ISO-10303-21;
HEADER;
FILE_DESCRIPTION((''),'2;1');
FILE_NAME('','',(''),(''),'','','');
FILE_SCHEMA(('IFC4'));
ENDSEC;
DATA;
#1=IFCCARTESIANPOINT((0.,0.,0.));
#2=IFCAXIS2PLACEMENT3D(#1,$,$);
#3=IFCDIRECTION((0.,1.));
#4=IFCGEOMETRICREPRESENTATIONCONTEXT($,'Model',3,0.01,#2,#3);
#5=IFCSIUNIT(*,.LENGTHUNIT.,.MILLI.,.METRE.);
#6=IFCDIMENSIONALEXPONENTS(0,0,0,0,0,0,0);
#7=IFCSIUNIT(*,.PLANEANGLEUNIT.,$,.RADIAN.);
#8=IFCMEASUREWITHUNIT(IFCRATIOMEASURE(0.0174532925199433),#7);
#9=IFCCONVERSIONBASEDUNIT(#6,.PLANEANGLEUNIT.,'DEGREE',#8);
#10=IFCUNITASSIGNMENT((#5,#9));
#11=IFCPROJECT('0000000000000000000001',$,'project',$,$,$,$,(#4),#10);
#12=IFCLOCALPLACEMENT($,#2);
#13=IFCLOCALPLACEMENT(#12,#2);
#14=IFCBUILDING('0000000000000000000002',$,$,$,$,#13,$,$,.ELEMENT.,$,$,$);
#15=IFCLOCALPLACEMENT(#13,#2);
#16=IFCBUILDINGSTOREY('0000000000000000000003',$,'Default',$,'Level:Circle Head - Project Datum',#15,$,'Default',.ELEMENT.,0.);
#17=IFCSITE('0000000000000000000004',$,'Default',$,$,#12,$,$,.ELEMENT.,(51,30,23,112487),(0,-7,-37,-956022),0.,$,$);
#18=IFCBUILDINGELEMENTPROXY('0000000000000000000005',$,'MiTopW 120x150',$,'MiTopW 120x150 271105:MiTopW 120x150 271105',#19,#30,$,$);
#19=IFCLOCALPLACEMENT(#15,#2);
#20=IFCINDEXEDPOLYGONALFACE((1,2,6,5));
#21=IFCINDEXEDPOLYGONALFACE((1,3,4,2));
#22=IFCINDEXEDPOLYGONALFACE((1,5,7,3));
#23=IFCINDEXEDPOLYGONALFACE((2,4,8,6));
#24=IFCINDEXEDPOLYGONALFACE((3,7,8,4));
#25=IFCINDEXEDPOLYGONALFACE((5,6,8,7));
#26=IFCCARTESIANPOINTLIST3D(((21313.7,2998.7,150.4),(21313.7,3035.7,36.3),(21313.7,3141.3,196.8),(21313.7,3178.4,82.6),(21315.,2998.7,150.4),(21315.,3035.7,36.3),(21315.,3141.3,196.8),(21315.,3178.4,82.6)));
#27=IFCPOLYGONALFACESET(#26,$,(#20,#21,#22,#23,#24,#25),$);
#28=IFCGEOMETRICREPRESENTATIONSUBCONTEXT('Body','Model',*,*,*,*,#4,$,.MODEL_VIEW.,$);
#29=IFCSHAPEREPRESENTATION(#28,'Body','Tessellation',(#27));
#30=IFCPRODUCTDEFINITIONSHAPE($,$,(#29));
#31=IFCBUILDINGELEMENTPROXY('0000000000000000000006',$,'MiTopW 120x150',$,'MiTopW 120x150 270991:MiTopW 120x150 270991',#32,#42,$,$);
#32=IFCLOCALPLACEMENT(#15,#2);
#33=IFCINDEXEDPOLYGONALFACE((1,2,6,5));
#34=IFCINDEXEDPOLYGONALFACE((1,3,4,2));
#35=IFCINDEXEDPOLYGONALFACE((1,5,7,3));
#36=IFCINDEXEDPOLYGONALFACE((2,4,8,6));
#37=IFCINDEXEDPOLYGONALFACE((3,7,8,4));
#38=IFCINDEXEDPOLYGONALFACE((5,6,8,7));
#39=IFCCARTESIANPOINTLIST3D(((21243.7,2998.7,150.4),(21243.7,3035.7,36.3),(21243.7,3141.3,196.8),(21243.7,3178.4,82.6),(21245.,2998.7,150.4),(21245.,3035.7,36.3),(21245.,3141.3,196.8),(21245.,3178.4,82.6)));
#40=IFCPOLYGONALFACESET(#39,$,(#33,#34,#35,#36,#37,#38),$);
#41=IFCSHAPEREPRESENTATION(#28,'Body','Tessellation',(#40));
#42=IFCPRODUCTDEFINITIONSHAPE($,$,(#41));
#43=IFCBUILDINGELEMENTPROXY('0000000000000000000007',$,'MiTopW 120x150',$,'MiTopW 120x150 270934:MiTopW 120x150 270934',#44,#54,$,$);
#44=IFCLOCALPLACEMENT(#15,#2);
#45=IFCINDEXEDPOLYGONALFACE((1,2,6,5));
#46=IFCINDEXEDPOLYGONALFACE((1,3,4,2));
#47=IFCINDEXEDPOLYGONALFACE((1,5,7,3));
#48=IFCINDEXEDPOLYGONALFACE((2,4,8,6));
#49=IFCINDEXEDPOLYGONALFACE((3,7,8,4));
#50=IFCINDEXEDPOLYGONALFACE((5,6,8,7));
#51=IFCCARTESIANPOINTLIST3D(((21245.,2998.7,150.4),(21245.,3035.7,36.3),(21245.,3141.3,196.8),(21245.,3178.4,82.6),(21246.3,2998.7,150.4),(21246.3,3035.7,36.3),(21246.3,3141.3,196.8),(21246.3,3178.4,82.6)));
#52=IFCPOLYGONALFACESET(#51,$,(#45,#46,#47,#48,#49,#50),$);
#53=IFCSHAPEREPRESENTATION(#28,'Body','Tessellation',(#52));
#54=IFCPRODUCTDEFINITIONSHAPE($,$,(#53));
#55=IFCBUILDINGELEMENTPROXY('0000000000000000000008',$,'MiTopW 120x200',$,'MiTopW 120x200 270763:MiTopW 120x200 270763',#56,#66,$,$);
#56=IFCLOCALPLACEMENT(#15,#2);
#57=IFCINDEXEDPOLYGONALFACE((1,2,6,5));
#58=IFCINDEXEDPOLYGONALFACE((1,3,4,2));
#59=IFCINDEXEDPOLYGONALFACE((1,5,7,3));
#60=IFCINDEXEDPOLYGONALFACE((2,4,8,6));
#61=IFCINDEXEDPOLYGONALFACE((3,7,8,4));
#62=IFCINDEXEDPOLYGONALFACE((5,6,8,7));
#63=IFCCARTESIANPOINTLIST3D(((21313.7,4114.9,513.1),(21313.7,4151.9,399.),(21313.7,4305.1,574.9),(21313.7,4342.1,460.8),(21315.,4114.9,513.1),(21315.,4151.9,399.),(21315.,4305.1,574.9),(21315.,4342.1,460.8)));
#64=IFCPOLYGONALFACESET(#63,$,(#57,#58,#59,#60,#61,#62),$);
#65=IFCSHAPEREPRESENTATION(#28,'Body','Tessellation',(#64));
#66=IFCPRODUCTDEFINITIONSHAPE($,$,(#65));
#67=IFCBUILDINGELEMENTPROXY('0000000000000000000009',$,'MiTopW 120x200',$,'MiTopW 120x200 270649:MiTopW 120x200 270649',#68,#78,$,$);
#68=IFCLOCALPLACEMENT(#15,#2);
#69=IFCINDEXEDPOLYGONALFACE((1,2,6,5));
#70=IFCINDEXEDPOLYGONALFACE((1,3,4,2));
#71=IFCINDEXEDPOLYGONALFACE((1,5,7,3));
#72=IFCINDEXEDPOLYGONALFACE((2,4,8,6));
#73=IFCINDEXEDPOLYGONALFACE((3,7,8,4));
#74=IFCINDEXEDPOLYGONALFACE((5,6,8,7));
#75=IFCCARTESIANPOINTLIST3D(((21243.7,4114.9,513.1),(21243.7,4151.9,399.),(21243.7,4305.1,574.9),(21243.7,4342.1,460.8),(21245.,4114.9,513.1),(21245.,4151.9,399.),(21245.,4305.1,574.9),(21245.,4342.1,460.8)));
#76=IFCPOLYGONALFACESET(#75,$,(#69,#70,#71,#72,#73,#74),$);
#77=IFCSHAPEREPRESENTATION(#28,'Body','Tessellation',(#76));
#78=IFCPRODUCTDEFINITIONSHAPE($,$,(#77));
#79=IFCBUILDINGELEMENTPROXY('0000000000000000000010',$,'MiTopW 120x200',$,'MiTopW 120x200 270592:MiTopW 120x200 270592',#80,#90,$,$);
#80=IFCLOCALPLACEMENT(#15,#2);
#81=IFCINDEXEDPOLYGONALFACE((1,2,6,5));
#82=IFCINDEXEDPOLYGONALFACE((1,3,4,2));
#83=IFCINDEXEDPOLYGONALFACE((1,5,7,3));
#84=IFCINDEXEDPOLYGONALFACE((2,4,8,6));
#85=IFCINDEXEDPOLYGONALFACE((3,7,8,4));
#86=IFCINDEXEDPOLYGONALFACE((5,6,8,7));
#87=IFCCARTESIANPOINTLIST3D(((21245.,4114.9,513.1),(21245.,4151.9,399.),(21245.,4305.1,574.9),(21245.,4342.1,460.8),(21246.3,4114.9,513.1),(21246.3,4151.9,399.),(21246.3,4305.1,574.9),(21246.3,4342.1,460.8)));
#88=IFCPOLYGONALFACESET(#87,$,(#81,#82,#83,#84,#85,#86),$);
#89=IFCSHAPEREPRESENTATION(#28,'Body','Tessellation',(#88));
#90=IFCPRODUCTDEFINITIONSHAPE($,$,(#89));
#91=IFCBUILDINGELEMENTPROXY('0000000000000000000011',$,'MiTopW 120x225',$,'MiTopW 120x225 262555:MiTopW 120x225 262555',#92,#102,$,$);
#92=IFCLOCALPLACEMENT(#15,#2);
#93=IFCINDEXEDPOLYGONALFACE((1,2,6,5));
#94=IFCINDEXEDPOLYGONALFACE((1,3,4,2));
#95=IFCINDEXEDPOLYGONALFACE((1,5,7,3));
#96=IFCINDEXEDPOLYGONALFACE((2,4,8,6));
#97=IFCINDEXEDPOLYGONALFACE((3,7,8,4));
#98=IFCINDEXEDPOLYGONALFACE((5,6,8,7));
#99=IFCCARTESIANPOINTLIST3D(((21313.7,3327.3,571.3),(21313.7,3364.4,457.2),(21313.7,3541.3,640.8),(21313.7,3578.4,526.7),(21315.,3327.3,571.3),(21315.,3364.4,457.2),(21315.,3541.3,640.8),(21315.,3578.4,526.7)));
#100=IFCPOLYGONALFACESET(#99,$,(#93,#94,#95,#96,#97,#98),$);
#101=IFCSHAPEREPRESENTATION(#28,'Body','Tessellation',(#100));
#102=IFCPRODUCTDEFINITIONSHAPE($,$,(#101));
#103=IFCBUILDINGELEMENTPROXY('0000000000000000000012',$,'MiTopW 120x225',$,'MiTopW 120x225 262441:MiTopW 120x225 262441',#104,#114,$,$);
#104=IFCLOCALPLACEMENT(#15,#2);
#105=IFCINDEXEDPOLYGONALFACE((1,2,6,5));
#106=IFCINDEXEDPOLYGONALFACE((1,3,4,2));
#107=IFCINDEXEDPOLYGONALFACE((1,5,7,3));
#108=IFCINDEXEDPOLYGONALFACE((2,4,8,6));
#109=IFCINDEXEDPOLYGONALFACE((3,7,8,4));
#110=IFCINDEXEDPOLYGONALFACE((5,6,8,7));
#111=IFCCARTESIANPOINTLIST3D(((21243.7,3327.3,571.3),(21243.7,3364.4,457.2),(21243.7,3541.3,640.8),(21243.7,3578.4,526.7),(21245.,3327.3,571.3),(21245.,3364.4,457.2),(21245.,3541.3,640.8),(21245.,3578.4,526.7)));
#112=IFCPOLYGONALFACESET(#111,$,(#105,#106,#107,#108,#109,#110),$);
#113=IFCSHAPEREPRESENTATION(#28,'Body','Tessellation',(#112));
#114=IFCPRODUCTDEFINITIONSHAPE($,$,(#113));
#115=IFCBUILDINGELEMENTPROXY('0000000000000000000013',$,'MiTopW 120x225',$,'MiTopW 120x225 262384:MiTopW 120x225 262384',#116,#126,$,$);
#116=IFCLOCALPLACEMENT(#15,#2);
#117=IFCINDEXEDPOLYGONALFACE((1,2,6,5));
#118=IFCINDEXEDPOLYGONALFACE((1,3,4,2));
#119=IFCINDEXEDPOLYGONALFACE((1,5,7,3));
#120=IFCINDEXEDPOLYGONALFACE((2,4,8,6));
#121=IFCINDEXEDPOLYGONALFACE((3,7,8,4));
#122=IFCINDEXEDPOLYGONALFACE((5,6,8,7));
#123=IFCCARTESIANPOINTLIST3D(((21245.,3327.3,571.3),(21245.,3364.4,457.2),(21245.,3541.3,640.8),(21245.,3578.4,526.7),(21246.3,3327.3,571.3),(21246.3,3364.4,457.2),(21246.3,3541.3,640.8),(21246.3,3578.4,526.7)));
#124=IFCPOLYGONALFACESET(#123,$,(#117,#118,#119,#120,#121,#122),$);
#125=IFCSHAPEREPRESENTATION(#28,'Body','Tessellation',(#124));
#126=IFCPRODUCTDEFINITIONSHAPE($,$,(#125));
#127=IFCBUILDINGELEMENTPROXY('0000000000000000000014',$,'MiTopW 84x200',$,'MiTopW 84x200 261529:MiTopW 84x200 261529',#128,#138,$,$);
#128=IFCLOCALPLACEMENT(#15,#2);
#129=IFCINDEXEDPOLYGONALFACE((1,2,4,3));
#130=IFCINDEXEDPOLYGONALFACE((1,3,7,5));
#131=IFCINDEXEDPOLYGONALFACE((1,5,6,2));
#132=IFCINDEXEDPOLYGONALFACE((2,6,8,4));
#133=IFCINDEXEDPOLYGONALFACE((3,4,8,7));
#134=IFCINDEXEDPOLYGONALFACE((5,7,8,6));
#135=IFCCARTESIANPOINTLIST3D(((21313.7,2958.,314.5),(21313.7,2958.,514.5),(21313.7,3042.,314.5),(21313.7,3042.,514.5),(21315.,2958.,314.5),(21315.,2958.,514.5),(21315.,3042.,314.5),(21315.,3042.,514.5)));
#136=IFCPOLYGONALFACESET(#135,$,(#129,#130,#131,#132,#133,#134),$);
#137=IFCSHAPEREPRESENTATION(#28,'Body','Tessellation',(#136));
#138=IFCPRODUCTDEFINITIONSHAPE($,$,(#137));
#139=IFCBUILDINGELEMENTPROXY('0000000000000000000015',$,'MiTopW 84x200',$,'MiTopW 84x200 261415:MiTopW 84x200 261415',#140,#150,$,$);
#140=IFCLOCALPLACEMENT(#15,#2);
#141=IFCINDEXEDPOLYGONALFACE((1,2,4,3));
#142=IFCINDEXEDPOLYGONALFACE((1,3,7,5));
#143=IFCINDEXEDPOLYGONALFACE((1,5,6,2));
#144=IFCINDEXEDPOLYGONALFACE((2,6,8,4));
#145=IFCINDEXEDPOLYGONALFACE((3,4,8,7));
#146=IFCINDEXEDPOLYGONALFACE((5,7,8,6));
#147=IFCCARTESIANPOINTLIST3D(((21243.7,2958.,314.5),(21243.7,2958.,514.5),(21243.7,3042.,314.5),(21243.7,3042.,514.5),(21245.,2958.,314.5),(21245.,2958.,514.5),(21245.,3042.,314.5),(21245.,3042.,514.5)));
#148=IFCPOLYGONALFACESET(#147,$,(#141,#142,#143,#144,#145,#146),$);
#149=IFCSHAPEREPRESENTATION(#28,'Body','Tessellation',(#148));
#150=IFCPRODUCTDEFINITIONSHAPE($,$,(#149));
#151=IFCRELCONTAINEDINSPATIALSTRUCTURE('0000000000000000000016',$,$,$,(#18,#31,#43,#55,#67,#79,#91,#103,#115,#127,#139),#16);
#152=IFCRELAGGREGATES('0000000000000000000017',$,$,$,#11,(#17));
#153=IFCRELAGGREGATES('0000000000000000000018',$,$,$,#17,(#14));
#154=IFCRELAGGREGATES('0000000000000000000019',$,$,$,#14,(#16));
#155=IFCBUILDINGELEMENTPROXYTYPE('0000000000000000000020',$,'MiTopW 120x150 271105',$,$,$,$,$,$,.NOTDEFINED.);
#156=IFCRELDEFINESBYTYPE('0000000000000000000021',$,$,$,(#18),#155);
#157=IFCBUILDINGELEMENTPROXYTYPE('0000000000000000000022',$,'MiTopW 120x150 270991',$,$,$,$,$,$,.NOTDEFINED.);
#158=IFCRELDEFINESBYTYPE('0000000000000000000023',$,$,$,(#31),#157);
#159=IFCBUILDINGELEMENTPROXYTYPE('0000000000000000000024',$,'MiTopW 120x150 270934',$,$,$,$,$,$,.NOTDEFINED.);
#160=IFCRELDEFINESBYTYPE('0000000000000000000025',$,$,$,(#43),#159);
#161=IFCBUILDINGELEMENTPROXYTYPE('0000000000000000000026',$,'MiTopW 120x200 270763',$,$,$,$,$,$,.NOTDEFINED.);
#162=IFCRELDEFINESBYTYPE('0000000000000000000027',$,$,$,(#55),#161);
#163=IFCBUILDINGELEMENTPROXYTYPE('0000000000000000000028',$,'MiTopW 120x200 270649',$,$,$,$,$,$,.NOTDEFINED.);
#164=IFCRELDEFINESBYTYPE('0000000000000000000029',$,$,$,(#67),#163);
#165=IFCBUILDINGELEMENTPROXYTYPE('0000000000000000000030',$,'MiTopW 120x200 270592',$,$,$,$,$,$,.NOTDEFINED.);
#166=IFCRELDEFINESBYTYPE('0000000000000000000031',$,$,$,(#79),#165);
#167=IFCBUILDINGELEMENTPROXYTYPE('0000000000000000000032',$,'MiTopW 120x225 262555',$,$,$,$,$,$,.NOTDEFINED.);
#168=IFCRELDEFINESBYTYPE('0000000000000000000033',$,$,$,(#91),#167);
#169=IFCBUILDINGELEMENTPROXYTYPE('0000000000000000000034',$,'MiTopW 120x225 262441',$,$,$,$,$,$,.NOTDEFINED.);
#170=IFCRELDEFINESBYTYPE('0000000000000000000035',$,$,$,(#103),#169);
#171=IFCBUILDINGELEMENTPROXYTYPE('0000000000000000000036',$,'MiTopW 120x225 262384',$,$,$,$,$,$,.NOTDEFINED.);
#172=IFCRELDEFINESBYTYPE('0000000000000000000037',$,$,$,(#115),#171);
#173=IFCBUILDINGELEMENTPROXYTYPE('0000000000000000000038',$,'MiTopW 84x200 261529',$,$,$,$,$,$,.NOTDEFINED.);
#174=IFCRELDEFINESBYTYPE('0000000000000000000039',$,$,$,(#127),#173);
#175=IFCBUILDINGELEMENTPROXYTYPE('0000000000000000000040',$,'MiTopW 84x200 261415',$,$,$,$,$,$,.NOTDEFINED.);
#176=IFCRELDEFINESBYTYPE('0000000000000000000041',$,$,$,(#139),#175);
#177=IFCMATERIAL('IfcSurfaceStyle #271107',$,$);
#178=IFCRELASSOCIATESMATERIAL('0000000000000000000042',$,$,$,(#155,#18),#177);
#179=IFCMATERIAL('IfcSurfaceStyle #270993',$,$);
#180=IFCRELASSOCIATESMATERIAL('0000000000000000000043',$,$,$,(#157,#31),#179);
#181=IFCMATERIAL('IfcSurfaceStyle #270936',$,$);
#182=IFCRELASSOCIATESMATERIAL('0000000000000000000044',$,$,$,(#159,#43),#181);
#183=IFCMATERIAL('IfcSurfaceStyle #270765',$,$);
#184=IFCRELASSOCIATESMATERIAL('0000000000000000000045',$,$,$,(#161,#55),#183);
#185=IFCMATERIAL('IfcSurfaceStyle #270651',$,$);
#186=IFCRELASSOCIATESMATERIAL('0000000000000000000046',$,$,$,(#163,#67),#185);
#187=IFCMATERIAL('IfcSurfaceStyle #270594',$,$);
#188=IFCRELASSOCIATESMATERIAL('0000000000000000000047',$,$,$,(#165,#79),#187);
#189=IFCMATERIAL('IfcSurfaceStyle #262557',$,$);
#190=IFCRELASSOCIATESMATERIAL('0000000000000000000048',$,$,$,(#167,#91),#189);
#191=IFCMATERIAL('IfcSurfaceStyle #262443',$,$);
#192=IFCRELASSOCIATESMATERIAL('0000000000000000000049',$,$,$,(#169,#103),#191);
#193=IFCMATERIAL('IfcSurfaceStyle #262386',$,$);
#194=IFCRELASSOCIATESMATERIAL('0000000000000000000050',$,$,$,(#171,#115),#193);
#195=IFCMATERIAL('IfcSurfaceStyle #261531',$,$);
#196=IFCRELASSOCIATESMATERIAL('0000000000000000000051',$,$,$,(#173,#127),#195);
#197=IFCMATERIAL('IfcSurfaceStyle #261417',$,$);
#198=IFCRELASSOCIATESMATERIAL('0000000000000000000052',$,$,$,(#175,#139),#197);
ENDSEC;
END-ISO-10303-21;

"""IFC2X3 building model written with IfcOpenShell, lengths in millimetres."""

from ifc_helpers import new_model, entity, si_unit, converted_unit, direction, frame, frame_2d, origin, place, context, subcontext, project, spatial, polyline, rectangle, outline, extrude, source, transform, mapped, material, type_object, type_shapes, element, save


model = new_model("IFC2X3")

# Units and contexts
model_context = context("Model", 3, precision=0.01, world=origin(), true_north=direction((0.0, 1.0)))
body_context = subcontext(model_context, "Body", "Model", "MODEL_VIEW")
ifc_project = project(units=[si_unit("LENGTHUNIT", "METRE", prefix="MILLI"), converted_unit("PLANEANGLEUNIT", "DEGREE", entity("IfcRatioMeasure", 0.0174532925199433), si_unit("PLANEANGLEUNIT", "RADIAN"), dimensions=[0, 0, 0, 0, 0, 0, 0])], contexts=[model_context])

# Site, building, storey
site_placement = place(None, origin())
site = spatial("IfcSite", under=ifc_project, at=site_placement, Name="Default", CompositionType="ELEMENT", RefLatitude=(51, 30, 23, 112487), RefLongitude=(0, -7, -37, -956022), RefElevation=0.0)
building_placement = place(site_placement, origin())
building = spatial("IfcBuilding", under=site, at=building_placement, CompositionType="ELEMENT")
storey_placement = place(building_placement, origin())
storey = spatial("IfcBuildingStorey", under=building, at=storey_placement, Name="Default", ObjectType="Level:Circle Head - Project Datum", LongName="Default", CompositionType="ELEMENT", Elevation=0.0)

# Building element proxies
ifc_material_1 = material(Name="IfcSurfaceStyle #271107")
building_element_proxy_type_1 = type_object("IfcBuildingElementProxyType", Name="MiTopW 120x150 271105", PredefinedType="NOTDEFINED", material=ifc_material_1)
shared_shape_1 = source(origin(), body_context, "Body", "SweptSolid", [
    extrude(outline(polyline([(-75.0, -60.0), (75.0, -60.0), (75.0, 60.0), (-75.0, 60.0), (-75.0, -60.0)])), frame((75.0, 60.0, 0.0), z_axis=(0.0, 0.0, 1.0), x_axis=(-1.0, 0.0, 0.0)), (0.0, 0.0, 1.0), 1.3),
])
type_shapes(building_element_proxy_type_1, [shared_shape_1])
proxy_1_placement = place(building_placement, frame((21315.0, 2998.7, 150.4), z_axis=(-1.0, 0.0, 0.0), x_axis=(0.0, 0.951057, 0.309017)))
element("IfcBuildingElementProxy", 1, at=proxy_1_placement, inside=storey, type_object=building_element_proxy_type_1, material=ifc_material_1, Name="MiTopW 120x150", ObjectType="MiTopW 120x150 271105:MiTopW 120x150 271105", context=body_context, shape_type="MappedRepresentation", body=[
    mapped(shared_shape_1, transform((0.0, 0.0, 0.0), scale=1.0)),
])
ifc_material_2 = material(Name="IfcSurfaceStyle #270993")
building_element_proxy_type_2 = type_object("IfcBuildingElementProxyType", Name="MiTopW 120x150 270991", PredefinedType="NOTDEFINED", material=ifc_material_2)
shared_shape_2 = source(origin(), body_context, "Body", "SweptSolid", [
    extrude(outline(polyline([(-75.0, -60.0), (75.0, -60.0), (75.0, 60.0), (-75.0, 60.0), (-75.0, -60.0)])), frame((75.0, 60.0, 0.0), z_axis=(0.0, 0.0, 1.0), x_axis=(-1.0, 0.0, 0.0)), (0.0, 0.0, 1.0), 1.3),
])
type_shapes(building_element_proxy_type_2, [shared_shape_2])
proxy_2_placement = place(building_placement, frame((21245.0, 2998.7, 150.4), z_axis=(-1.0, 0.0, 0.0), x_axis=(0.0, 0.951057, 0.309017)))
element("IfcBuildingElementProxy", 2, at=proxy_2_placement, inside=storey, type_object=building_element_proxy_type_2, material=ifc_material_2, Name="MiTopW 120x150", ObjectType="MiTopW 120x150 270991:MiTopW 120x150 270991", context=body_context, shape_type="MappedRepresentation", body=[
    mapped(shared_shape_2, transform((0.0, 0.0, 0.0), scale=1.0)),
])
ifc_material_3 = material(Name="IfcSurfaceStyle #270936")
building_element_proxy_type_3 = type_object("IfcBuildingElementProxyType", Name="MiTopW 120x150 270934", PredefinedType="NOTDEFINED", material=ifc_material_3)
shared_shape_3 = source(origin(), body_context, "Body", "SweptSolid", [
    extrude(outline(polyline([(-75.0, -60.0), (75.0, -60.0), (75.0, 60.0), (-75.0, 60.0), (-75.0, -60.0)])), frame((75.0, 60.0, 0.0), z_axis=(0.0, 0.0, 1.0), x_axis=(-1.0, 0.0, 0.0)), (0.0, 0.0, 1.0), 1.3),
])
type_shapes(building_element_proxy_type_3, [shared_shape_3])
proxy_3_placement = place(building_placement, frame((21246.3, 2998.7, 150.4), z_axis=(-1.0, 0.0, 0.0), x_axis=(0.0, 0.951057, 0.309017)))
element("IfcBuildingElementProxy", 3, at=proxy_3_placement, inside=storey, type_object=building_element_proxy_type_3, material=ifc_material_3, Name="MiTopW 120x150", ObjectType="MiTopW 120x150 270934:MiTopW 120x150 270934", context=body_context, shape_type="MappedRepresentation", body=[
    mapped(shared_shape_3, transform((0.0, 0.0, 0.0), scale=1.0)),
])
ifc_material_4 = material(Name="IfcSurfaceStyle #270765")
building_element_proxy_type_4 = type_object("IfcBuildingElementProxyType", Name="MiTopW 120x200 270763", PredefinedType="NOTDEFINED", material=ifc_material_4)
shared_shape_4 = source(origin(), body_context, "Body", "SweptSolid", [
    extrude(outline(polyline([(-100.0, -60.0), (100.0, -60.0), (100.0, 60.0), (-100.0, 60.0), (-100.0, -60.0)])), frame((100.0, 60.0, 0.0), z_axis=(0.0, 0.0, 1.0), x_axis=(-1.0, 0.0, 0.0)), (0.0, 0.0, 1.0), 1.3),
])
type_shapes(building_element_proxy_type_4, [shared_shape_4])
proxy_4_placement = place(building_placement, frame((21315.0, 4114.9, 513.1), z_axis=(-1.0, 0.0, 0.0), x_axis=(0.0, 0.951057, 0.309017)))
element("IfcBuildingElementProxy", 4, at=proxy_4_placement, inside=storey, type_object=building_element_proxy_type_4, material=ifc_material_4, Name="MiTopW 120x200", ObjectType="MiTopW 120x200 270763:MiTopW 120x200 270763", context=body_context, shape_type="MappedRepresentation", body=[
    mapped(shared_shape_4, transform((0.0, 0.0, 0.0), scale=1.0)),
])
ifc_material_5 = material(Name="IfcSurfaceStyle #270651")
building_element_proxy_type_5 = type_object("IfcBuildingElementProxyType", Name="MiTopW 120x200 270649", PredefinedType="NOTDEFINED", material=ifc_material_5)
shared_shape_5 = source(origin(), body_context, "Body", "SweptSolid", [
    extrude(outline(polyline([(-100.0, -60.0), (100.0, -60.0), (100.0, 60.0), (-100.0, 60.0), (-100.0, -60.0)])), frame((100.0, 60.0, 0.0), z_axis=(0.0, 0.0, 1.0), x_axis=(-1.0, 0.0, 0.0)), (0.0, 0.0, 1.0), 1.3),
])
type_shapes(building_element_proxy_type_5, [shared_shape_5])
proxy_5_placement = place(building_placement, frame((21245.0, 4114.9, 513.1), z_axis=(-1.0, 0.0, 0.0), x_axis=(0.0, 0.951057, 0.309017)))
element("IfcBuildingElementProxy", 5, at=proxy_5_placement, inside=storey, type_object=building_element_proxy_type_5, material=ifc_material_5, Name="MiTopW 120x200", ObjectType="MiTopW 120x200 270649:MiTopW 120x200 270649", context=body_context, shape_type="MappedRepresentation", body=[
    mapped(shared_shape_5, transform((0.0, 0.0, 0.0), scale=1.0)),
])
ifc_material_6 = material(Name="IfcSurfaceStyle #270594")
building_element_proxy_type_6 = type_object("IfcBuildingElementProxyType", Name="MiTopW 120x200 270592", PredefinedType="NOTDEFINED", material=ifc_material_6)
shared_shape_6 = source(origin(), body_context, "Body", "SweptSolid", [
    extrude(outline(polyline([(-100.0, -60.0), (100.0, -60.0), (100.0, 60.0), (-100.0, 60.0), (-100.0, -60.0)])), frame((100.0, 60.0, 0.0), z_axis=(0.0, 0.0, 1.0), x_axis=(-1.0, 0.0, 0.0)), (0.0, 0.0, 1.0), 1.3),
])
type_shapes(building_element_proxy_type_6, [shared_shape_6])
proxy_6_placement = place(building_placement, frame((21246.3, 4114.9, 513.1), z_axis=(-1.0, 0.0, 0.0), x_axis=(0.0, 0.951057, 0.309017)))
element("IfcBuildingElementProxy", 6, at=proxy_6_placement, inside=storey, type_object=building_element_proxy_type_6, material=ifc_material_6, Name="MiTopW 120x200", ObjectType="MiTopW 120x200 270592:MiTopW 120x200 270592", context=body_context, shape_type="MappedRepresentation", body=[
    mapped(shared_shape_6, transform((0.0, 0.0, 0.0), scale=1.0)),
])
ifc_material_7 = material(Name="IfcSurfaceStyle #262557")
building_element_proxy_type_7 = type_object("IfcBuildingElementProxyType", Name="MiTopW 120x225 262555", PredefinedType="NOTDEFINED", material=ifc_material_7)
shared_shape_7 = source(origin(), body_context, "Body", "SweptSolid", [
    extrude(outline(polyline([(-112.5, -60.0), (112.5, -60.0), (112.5, 60.0), (-112.5, 60.0), (-112.5, -60.0)])), frame((112.5, 60.0, 0.0), z_axis=(0.0, 0.0, 1.0), x_axis=(-1.0, 0.0, 0.0)), (0.0, 0.0, 1.0), 1.3),
])
type_shapes(building_element_proxy_type_7, [shared_shape_7])
proxy_7_placement = place(building_placement, frame((21315.0, 3327.3, 571.3), z_axis=(-1.0, 0.0, 0.0), x_axis=(0.0, 0.951057, 0.309017)))
element("IfcBuildingElementProxy", 7, at=proxy_7_placement, inside=storey, type_object=building_element_proxy_type_7, material=ifc_material_7, Name="MiTopW 120x225", ObjectType="MiTopW 120x225 262555:MiTopW 120x225 262555", context=body_context, shape_type="MappedRepresentation", body=[
    mapped(shared_shape_7, transform((0.0, 0.0, 0.0), scale=1.0)),
])
ifc_material_8 = material(Name="IfcSurfaceStyle #262443")
building_element_proxy_type_8 = type_object("IfcBuildingElementProxyType", Name="MiTopW 120x225 262441", PredefinedType="NOTDEFINED", material=ifc_material_8)
shared_shape_8 = source(origin(), body_context, "Body", "SweptSolid", [
    extrude(outline(polyline([(-112.5, -60.0), (112.5, -60.0), (112.5, 60.0), (-112.5, 60.0), (-112.5, -60.0)])), frame((112.5, 60.0, 0.0), z_axis=(0.0, 0.0, 1.0), x_axis=(-1.0, 0.0, 0.0)), (0.0, 0.0, 1.0), 1.3),
])
type_shapes(building_element_proxy_type_8, [shared_shape_8])
proxy_8_placement = place(building_placement, frame((21245.0, 3327.3, 571.3), z_axis=(-1.0, 0.0, 0.0), x_axis=(0.0, 0.951057, 0.309017)))
element("IfcBuildingElementProxy", 8, at=proxy_8_placement, inside=storey, type_object=building_element_proxy_type_8, material=ifc_material_8, Name="MiTopW 120x225", ObjectType="MiTopW 120x225 262441:MiTopW 120x225 262441", context=body_context, shape_type="MappedRepresentation", body=[
    mapped(shared_shape_8, transform((0.0, 0.0, 0.0), scale=1.0)),
])
ifc_material_9 = material(Name="IfcSurfaceStyle #262386")
building_element_proxy_type_9 = type_object("IfcBuildingElementProxyType", Name="MiTopW 120x225 262384", PredefinedType="NOTDEFINED", material=ifc_material_9)
shared_shape_9 = source(origin(), body_context, "Body", "SweptSolid", [
    extrude(outline(polyline([(-112.5, -60.0), (112.5, -60.0), (112.5, 60.0), (-112.5, 60.0), (-112.5, -60.0)])), frame((112.5, 60.0, 0.0), z_axis=(0.0, 0.0, 1.0), x_axis=(-1.0, 0.0, 0.0)), (0.0, 0.0, 1.0), 1.3),
])
type_shapes(building_element_proxy_type_9, [shared_shape_9])
proxy_9_placement = place(building_placement, frame((21246.3, 3327.3, 571.3), z_axis=(-1.0, 0.0, 0.0), x_axis=(0.0, 0.951057, 0.309017)))
element("IfcBuildingElementProxy", 9, at=proxy_9_placement, inside=storey, type_object=building_element_proxy_type_9, material=ifc_material_9, Name="MiTopW 120x225", ObjectType="MiTopW 120x225 262384:MiTopW 120x225 262384", context=body_context, shape_type="MappedRepresentation", body=[
    mapped(shared_shape_9, transform((0.0, 0.0, 0.0), scale=1.0)),
])
ifc_material_10 = material(Name="IfcSurfaceStyle #261531")
building_element_proxy_type_10 = type_object("IfcBuildingElementProxyType", Name="MiTopW 84x200 261529", PredefinedType="NOTDEFINED", material=ifc_material_10)
shared_shape_10 = source(origin(), body_context, "Body", "SweptSolid", [
    extrude(rectangle(XDim=200.0, YDim=84.0, at=frame_2d((0.0, 0.0), x_axis=(1.0, 0.0))), frame((100.0, 42.0, 0.0), z_axis=(0.0, 0.0, 1.0), x_axis=(-1.0, 0.0, 0.0)), (0.0, 0.0, 1.0), 1.3),
])
type_shapes(building_element_proxy_type_10, [shared_shape_10])
proxy_10_placement = place(building_placement, frame((21315.0, 3042.0, 514.5), z_axis=(-1.0, 0.0, 0.0), x_axis=(0.0, 0.0, -1.0)))
element("IfcBuildingElementProxy", 10, at=proxy_10_placement, inside=storey, type_object=building_element_proxy_type_10, material=ifc_material_10, Name="MiTopW 84x200", ObjectType="MiTopW 84x200 261529:MiTopW 84x200 261529", context=body_context, shape_type="MappedRepresentation", body=[
    mapped(shared_shape_10, transform((0.0, 0.0, 0.0), scale=1.0)),
])
ifc_material_11 = material(Name="IfcSurfaceStyle #261417")
building_element_proxy_type_11 = type_object("IfcBuildingElementProxyType", Name="MiTopW 84x200 261415", PredefinedType="NOTDEFINED", material=ifc_material_11)
shared_shape_11 = source(origin(), body_context, "Body", "SweptSolid", [
    extrude(rectangle(XDim=200.0, YDim=84.0, at=frame_2d((0.0, 0.0), x_axis=(1.0, 0.0))), frame((100.0, 42.0, 0.0), z_axis=(0.0, 0.0, 1.0), x_axis=(-1.0, 0.0, 0.0)), (0.0, 0.0, 1.0), 1.3),
])
type_shapes(building_element_proxy_type_11, [shared_shape_11])
proxy_11_placement = place(building_placement, frame((21245.0, 3042.0, 514.5), z_axis=(-1.0, 0.0, 0.0), x_axis=(0.0, 0.0, -1.0)))
element("IfcBuildingElementProxy", 11, at=proxy_11_placement, inside=storey, type_object=building_element_proxy_type_11, material=ifc_material_11, Name="MiTopW 84x200", ObjectType="MiTopW 84x200 261415:MiTopW 84x200 261415", context=body_context, shape_type="MappedRepresentation", body=[
    mapped(shared_shape_11, transform((0.0, 0.0, 0.0), scale=1.0)),
])

save(model, "model.ifc")
